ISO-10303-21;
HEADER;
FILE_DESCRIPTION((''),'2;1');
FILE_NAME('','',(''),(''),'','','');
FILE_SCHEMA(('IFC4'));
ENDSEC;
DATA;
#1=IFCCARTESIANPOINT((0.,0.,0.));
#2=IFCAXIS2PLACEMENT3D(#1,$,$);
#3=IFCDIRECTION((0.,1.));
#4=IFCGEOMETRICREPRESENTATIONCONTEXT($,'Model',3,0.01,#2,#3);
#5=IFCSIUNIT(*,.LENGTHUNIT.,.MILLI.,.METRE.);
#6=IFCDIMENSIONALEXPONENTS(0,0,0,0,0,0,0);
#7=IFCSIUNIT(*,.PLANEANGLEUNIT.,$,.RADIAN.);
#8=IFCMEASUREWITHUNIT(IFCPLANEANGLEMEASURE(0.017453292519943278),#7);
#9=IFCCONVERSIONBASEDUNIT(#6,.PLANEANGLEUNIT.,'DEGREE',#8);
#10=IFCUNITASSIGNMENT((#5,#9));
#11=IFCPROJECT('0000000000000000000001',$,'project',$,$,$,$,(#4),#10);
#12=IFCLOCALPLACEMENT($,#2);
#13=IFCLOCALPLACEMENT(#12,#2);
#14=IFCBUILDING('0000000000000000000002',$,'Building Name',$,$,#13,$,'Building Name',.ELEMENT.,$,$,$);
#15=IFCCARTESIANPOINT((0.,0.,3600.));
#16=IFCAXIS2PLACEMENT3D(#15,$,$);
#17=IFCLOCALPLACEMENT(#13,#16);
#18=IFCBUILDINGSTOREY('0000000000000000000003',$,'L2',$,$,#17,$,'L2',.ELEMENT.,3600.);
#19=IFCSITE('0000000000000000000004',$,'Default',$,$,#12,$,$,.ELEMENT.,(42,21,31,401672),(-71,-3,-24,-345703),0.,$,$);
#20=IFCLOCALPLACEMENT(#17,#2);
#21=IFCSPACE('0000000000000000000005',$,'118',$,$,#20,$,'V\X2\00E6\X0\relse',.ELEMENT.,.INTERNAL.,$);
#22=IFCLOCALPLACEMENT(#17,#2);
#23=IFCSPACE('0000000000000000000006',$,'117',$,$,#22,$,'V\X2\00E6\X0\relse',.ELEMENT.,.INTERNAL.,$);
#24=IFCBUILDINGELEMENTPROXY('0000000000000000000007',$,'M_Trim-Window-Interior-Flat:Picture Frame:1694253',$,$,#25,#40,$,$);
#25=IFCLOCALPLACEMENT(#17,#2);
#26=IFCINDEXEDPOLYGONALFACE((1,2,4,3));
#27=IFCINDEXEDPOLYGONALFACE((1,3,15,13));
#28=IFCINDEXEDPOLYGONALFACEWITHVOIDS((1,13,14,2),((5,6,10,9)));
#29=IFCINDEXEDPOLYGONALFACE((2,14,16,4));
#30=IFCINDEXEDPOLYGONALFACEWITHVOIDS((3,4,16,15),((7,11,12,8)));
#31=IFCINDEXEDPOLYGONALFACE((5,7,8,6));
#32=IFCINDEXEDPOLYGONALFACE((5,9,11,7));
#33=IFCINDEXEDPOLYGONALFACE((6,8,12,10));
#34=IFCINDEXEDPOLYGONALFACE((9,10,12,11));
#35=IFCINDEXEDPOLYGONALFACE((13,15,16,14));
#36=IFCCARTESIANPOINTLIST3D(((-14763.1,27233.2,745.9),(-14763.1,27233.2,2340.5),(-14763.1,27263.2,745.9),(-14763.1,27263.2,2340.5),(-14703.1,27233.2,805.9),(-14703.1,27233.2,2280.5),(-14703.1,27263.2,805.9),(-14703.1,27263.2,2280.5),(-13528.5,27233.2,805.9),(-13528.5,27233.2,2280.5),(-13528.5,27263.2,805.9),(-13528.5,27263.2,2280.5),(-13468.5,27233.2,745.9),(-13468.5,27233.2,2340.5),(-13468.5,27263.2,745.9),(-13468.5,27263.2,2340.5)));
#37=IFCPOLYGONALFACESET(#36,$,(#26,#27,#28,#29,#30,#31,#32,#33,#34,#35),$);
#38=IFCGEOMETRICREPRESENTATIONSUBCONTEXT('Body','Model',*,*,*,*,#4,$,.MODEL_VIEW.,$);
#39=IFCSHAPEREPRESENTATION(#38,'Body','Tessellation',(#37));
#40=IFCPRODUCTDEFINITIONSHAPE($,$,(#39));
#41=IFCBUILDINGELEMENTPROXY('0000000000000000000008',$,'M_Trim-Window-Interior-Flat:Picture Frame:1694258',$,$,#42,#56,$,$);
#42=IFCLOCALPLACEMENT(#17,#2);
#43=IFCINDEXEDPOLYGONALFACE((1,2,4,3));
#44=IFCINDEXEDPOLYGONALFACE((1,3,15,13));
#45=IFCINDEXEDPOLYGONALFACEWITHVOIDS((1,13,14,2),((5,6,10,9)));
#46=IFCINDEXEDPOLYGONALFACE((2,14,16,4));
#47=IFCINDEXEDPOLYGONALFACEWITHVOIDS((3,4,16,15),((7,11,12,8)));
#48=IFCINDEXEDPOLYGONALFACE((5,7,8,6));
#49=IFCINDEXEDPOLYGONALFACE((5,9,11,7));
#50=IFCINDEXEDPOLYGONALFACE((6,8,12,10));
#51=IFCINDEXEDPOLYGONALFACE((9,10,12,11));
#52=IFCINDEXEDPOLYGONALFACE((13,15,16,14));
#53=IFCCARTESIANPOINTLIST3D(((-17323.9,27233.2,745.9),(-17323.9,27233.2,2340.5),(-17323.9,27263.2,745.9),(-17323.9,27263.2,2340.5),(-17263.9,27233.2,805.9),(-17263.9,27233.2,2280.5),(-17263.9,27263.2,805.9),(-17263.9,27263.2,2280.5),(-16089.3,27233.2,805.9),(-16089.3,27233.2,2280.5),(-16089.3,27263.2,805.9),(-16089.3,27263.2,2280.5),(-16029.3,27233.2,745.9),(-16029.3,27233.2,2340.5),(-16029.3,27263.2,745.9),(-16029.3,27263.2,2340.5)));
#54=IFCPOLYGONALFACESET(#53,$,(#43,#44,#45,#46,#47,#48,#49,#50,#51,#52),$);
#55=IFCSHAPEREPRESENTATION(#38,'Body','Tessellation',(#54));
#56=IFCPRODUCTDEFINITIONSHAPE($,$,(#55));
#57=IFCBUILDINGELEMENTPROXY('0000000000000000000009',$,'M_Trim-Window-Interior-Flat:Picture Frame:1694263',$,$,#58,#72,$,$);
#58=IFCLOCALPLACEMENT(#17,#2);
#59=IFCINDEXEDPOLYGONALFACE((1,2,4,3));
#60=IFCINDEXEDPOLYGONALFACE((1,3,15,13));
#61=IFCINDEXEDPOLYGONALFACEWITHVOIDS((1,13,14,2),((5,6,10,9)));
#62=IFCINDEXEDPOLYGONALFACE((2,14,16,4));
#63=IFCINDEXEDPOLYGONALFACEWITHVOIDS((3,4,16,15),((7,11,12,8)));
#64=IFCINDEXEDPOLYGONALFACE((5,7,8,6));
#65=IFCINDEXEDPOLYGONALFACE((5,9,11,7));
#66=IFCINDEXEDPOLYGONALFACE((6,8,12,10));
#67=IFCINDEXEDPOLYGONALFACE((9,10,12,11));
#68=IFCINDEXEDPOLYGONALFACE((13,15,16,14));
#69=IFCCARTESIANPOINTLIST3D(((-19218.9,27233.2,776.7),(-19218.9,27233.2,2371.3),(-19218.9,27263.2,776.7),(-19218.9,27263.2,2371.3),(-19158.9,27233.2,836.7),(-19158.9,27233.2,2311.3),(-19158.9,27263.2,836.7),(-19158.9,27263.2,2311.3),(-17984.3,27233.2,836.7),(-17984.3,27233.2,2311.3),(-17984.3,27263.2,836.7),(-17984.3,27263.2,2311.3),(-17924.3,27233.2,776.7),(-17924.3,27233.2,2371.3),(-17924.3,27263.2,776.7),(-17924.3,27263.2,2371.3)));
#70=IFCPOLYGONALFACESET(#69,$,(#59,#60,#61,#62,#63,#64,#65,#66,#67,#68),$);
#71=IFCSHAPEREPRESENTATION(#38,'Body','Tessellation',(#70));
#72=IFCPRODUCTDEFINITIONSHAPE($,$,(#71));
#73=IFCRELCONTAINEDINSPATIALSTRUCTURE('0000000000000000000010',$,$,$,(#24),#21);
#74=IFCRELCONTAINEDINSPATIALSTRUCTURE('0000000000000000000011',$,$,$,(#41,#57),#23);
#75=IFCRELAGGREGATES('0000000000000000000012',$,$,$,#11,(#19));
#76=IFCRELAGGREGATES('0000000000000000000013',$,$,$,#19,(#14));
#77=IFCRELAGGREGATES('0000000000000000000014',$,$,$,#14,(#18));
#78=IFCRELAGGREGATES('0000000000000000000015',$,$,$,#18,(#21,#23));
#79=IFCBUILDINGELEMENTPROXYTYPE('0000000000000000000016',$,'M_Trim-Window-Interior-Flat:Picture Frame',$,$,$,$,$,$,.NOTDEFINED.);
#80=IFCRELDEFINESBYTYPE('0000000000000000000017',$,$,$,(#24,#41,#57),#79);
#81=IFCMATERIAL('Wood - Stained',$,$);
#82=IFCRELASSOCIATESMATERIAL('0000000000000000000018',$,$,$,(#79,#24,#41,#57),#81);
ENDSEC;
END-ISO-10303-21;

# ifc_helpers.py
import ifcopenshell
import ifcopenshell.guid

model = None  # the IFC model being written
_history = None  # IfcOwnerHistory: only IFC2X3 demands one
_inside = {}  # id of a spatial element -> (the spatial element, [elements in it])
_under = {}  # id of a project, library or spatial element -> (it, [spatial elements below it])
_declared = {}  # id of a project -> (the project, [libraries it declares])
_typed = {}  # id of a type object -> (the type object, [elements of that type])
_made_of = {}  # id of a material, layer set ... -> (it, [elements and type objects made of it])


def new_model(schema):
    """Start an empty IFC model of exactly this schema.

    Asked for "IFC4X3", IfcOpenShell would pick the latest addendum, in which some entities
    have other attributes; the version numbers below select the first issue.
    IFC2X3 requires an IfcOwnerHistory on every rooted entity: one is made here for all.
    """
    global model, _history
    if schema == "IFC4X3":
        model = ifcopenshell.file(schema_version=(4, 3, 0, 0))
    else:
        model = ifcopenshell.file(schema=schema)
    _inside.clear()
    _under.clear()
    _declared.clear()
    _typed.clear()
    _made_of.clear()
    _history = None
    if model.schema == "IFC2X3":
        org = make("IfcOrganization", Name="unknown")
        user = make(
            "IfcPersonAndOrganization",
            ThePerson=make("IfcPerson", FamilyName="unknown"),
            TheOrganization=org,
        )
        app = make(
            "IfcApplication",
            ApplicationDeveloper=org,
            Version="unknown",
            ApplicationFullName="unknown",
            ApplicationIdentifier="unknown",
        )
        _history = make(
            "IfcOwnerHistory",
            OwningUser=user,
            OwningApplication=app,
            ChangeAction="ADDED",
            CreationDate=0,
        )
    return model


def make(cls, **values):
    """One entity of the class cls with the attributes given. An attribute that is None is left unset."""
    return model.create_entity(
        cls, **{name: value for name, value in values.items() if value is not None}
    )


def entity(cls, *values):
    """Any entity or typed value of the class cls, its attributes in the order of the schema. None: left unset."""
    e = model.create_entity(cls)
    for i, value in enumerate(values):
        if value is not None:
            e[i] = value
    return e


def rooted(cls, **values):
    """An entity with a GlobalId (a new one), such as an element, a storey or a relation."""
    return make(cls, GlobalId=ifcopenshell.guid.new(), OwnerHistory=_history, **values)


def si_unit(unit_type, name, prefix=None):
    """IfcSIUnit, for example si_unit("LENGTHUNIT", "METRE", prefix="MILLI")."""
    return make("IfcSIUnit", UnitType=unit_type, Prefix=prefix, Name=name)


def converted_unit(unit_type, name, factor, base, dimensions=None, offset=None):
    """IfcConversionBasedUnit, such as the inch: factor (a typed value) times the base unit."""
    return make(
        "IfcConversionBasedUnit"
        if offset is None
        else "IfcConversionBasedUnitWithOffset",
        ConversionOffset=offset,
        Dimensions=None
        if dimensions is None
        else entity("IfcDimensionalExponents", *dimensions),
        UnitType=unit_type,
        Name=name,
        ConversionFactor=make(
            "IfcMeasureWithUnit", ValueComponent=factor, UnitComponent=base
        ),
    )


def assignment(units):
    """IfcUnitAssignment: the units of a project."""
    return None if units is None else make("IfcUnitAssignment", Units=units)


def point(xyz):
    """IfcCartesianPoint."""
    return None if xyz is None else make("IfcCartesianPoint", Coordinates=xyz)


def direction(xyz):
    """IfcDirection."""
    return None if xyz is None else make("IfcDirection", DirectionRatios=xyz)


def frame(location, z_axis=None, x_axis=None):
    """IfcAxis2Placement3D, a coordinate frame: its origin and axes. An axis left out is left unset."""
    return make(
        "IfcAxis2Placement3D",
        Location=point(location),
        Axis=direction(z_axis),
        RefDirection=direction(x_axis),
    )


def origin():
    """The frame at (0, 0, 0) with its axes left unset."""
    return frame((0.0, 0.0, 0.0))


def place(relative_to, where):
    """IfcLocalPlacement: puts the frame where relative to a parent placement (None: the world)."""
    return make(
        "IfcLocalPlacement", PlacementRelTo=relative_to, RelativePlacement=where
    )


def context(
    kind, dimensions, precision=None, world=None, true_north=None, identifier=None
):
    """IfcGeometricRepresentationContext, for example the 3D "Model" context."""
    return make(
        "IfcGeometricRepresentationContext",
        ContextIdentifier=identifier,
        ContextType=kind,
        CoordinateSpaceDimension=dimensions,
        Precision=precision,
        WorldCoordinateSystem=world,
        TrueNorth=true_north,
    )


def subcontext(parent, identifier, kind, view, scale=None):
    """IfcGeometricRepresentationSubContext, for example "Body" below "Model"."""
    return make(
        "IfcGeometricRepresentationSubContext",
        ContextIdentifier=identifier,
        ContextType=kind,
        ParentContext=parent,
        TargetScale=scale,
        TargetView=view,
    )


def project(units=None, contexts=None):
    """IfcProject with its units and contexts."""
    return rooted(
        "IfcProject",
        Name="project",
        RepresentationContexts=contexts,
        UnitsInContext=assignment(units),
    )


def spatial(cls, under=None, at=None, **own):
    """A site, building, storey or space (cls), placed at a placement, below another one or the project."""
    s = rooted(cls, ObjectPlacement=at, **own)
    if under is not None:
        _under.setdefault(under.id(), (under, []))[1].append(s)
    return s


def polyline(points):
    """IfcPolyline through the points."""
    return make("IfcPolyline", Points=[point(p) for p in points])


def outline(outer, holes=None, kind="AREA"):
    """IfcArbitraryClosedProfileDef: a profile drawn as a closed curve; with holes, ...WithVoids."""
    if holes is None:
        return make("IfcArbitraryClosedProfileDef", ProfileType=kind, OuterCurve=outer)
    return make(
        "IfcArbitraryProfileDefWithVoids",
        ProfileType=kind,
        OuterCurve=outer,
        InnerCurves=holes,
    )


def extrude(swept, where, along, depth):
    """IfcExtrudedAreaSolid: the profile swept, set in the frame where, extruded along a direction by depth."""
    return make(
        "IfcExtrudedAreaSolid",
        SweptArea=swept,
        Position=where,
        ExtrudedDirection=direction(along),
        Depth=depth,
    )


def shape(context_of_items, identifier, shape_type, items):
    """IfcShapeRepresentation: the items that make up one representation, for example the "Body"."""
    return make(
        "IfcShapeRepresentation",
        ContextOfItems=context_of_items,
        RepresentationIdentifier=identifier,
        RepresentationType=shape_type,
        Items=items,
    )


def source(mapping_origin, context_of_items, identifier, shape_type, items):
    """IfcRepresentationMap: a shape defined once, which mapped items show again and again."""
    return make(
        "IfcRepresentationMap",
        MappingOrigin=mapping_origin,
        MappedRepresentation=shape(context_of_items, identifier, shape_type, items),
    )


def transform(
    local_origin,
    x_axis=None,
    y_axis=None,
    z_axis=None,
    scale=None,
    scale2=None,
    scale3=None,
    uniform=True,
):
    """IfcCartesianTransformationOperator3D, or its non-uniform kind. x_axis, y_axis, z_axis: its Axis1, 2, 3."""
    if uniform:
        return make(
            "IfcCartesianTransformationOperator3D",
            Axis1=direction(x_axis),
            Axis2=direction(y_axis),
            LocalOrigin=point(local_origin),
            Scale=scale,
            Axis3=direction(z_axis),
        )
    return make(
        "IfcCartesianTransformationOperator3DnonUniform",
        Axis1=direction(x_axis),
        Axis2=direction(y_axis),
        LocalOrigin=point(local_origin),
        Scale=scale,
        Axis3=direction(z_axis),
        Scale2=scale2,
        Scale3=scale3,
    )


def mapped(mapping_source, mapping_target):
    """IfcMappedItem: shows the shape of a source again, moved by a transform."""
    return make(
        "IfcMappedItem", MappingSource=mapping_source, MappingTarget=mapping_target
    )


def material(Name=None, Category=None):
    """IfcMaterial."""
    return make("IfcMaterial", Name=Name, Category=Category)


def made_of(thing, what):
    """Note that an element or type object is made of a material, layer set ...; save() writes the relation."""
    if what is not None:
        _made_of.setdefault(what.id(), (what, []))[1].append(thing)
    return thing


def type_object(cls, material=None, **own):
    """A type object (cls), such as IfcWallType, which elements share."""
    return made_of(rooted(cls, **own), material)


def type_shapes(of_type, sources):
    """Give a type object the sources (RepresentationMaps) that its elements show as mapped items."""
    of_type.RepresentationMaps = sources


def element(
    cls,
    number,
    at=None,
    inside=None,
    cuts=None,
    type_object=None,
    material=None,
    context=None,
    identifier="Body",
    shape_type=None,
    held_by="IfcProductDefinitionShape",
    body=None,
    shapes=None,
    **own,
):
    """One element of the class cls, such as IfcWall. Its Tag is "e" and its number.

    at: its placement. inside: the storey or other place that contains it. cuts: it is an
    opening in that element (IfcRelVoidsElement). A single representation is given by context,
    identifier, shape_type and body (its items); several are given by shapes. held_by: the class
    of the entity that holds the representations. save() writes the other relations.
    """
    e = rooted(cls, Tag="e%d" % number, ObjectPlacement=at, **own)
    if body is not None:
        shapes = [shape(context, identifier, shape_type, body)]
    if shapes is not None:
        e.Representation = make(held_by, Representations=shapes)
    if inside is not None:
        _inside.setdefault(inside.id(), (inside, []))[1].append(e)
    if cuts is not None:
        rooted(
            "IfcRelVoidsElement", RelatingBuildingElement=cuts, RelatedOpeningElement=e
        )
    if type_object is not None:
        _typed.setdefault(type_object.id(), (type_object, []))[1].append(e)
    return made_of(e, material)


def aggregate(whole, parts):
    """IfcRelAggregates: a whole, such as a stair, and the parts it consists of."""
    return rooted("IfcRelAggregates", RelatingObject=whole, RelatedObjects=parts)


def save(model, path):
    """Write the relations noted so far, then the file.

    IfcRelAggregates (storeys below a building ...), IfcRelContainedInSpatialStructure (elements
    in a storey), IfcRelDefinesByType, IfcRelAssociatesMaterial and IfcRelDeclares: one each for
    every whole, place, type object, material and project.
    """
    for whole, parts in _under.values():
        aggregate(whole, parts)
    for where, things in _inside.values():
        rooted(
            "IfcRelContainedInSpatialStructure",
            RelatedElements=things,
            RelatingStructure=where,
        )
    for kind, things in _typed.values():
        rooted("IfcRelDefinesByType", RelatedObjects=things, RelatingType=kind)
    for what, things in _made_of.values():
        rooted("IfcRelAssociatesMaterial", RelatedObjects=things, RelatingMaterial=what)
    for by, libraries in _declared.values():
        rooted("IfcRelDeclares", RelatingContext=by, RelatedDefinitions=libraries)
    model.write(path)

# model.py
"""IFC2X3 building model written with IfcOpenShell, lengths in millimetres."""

from ifc_helpers import new_model, entity, si_unit, converted_unit, direction, frame, origin, place, context, subcontext, project, spatial, polyline, outline, extrude, source, transform, mapped, material, type_object, type_shapes, element, save


model = new_model("IFC2X3")

# Units and contexts
model_context = context("Model", 3, precision=0.01, world=origin(), true_north=direction((0.0, 1.0)))
body_context = subcontext(model_context, "Body", "Model", "MODEL_VIEW")
ifc_project = project(units=[si_unit("LENGTHUNIT", "METRE", prefix="MILLI"), converted_unit("PLANEANGLEUNIT", "DEGREE", entity("IfcPlaneAngleMeasure", 0.017453292519943278), si_unit("PLANEANGLEUNIT", "RADIAN"), dimensions=[0, 0, 0, 0, 0, 0, 0])], contexts=[model_context])

# Site, building, storey
site_placement = place(None, origin())
site = spatial("IfcSite", under=ifc_project, at=site_placement, Name="Default", CompositionType="ELEMENT", RefLatitude=(42, 21, 31, 401672), RefLongitude=(-71, -3, -24, -345703), RefElevation=0.0)
building_placement = place(site_placement, origin())
building = spatial("IfcBuilding", under=site, at=building_placement, Name="Building Name", LongName="Building Name", CompositionType="ELEMENT")
storey_placement = place(building_placement, frame((0.0, 0.0, 3600.0)))
storey = spatial("IfcBuildingStorey", under=building, at=storey_placement, Name="L2", LongName="L2", CompositionType="ELEMENT", Elevation=3600.0)

# Shared definitions
ifc_material_1 = material(Name="Wood - Stained")

# Shared definitions
space_1_placement = place(storey_placement, origin())
space_1 = spatial("IfcSpace", under=storey, at=space_1_placement, Name="118", LongName="Værelse", CompositionType="ELEMENT", InteriorOrExteriorSpace="INTERNAL")

# Building element proxy
building_element_proxy_type_1 = type_object("IfcBuildingElementProxyType", Name="M_Trim-Window-Interior-Flat:Picture Frame", PredefinedType="NOTDEFINED", material=ifc_material_1)
shared_shape_1 = source(origin(), body_context, "Body", "SweptSolid", [
    extrude(outline(polyline([(-647.3, -797.3), (647.3, -797.3), (647.3, 797.3), (-647.3, 797.3), (-647.3, -797.3)]), holes=[polyline([(-587.3, -737.3), (-587.3, 737.3), (587.3, 737.3), (587.3, -737.3), (-587.3, -737.3)])]), frame((0.0, -750.0, 0.0), z_axis=(0.0, 0.0, 1.0), x_axis=(-1.0, 0.0, 0.0)), (0.0, 0.0, 1.0), 30.0),
])
type_shapes(building_element_proxy_type_1, [shared_shape_1])
for number, where, z_axis, x_axis, name in (
    (1, (-14115.8, 27263.2, 2293.2), (0.0, -1.0, 0.0), (1.0, 0.0, 0.0), "M_Trim-Window-Interior-Flat:Picture Frame:1694253"),
):
    element("IfcBuildingElementProxy", number, at=place(space_1_placement, frame(where, z_axis=z_axis, x_axis=x_axis)), inside=space_1, type_object=building_element_proxy_type_1, material=ifc_material_1, Name=name, context=body_context, shape_type="MappedRepresentation", body=[
        mapped(shared_shape_1, transform((0.0, 0.0, 0.0), scale=1.0)),
    ])

# Shared definitions
space_2_placement = place(storey_placement, origin())
space_2 = spatial("IfcSpace", under=storey, at=space_2_placement, Name="117", LongName="Værelse", CompositionType="ELEMENT", InteriorOrExteriorSpace="INTERNAL")

# Building element proxies
for number, where, z_axis, x_axis, name in (
    (2, (-16676.6, 27263.2, 2293.2), (0.0, -1.0, 0.0), (1.0, 0.0, 0.0), "M_Trim-Window-Interior-Flat:Picture Frame:1694258"),
    (3, (-18571.6, 27263.2, 2324.0), (0.0, -1.0, 0.0), (1.0, 0.0, 0.0), "M_Trim-Window-Interior-Flat:Picture Frame:1694263"),
):
    element("IfcBuildingElementProxy", number, at=place(space_2_placement, frame(where, z_axis=z_axis, x_axis=x_axis)), inside=space_2, type_object=building_element_proxy_type_1, material=ifc_material_1, Name=name, context=body_context, shape_type="MappedRepresentation", body=[
        mapped(shared_shape_1, transform((0.0, 0.0, 0.0), scale=1.0)),
    ])

save(model, "model.ifc")
